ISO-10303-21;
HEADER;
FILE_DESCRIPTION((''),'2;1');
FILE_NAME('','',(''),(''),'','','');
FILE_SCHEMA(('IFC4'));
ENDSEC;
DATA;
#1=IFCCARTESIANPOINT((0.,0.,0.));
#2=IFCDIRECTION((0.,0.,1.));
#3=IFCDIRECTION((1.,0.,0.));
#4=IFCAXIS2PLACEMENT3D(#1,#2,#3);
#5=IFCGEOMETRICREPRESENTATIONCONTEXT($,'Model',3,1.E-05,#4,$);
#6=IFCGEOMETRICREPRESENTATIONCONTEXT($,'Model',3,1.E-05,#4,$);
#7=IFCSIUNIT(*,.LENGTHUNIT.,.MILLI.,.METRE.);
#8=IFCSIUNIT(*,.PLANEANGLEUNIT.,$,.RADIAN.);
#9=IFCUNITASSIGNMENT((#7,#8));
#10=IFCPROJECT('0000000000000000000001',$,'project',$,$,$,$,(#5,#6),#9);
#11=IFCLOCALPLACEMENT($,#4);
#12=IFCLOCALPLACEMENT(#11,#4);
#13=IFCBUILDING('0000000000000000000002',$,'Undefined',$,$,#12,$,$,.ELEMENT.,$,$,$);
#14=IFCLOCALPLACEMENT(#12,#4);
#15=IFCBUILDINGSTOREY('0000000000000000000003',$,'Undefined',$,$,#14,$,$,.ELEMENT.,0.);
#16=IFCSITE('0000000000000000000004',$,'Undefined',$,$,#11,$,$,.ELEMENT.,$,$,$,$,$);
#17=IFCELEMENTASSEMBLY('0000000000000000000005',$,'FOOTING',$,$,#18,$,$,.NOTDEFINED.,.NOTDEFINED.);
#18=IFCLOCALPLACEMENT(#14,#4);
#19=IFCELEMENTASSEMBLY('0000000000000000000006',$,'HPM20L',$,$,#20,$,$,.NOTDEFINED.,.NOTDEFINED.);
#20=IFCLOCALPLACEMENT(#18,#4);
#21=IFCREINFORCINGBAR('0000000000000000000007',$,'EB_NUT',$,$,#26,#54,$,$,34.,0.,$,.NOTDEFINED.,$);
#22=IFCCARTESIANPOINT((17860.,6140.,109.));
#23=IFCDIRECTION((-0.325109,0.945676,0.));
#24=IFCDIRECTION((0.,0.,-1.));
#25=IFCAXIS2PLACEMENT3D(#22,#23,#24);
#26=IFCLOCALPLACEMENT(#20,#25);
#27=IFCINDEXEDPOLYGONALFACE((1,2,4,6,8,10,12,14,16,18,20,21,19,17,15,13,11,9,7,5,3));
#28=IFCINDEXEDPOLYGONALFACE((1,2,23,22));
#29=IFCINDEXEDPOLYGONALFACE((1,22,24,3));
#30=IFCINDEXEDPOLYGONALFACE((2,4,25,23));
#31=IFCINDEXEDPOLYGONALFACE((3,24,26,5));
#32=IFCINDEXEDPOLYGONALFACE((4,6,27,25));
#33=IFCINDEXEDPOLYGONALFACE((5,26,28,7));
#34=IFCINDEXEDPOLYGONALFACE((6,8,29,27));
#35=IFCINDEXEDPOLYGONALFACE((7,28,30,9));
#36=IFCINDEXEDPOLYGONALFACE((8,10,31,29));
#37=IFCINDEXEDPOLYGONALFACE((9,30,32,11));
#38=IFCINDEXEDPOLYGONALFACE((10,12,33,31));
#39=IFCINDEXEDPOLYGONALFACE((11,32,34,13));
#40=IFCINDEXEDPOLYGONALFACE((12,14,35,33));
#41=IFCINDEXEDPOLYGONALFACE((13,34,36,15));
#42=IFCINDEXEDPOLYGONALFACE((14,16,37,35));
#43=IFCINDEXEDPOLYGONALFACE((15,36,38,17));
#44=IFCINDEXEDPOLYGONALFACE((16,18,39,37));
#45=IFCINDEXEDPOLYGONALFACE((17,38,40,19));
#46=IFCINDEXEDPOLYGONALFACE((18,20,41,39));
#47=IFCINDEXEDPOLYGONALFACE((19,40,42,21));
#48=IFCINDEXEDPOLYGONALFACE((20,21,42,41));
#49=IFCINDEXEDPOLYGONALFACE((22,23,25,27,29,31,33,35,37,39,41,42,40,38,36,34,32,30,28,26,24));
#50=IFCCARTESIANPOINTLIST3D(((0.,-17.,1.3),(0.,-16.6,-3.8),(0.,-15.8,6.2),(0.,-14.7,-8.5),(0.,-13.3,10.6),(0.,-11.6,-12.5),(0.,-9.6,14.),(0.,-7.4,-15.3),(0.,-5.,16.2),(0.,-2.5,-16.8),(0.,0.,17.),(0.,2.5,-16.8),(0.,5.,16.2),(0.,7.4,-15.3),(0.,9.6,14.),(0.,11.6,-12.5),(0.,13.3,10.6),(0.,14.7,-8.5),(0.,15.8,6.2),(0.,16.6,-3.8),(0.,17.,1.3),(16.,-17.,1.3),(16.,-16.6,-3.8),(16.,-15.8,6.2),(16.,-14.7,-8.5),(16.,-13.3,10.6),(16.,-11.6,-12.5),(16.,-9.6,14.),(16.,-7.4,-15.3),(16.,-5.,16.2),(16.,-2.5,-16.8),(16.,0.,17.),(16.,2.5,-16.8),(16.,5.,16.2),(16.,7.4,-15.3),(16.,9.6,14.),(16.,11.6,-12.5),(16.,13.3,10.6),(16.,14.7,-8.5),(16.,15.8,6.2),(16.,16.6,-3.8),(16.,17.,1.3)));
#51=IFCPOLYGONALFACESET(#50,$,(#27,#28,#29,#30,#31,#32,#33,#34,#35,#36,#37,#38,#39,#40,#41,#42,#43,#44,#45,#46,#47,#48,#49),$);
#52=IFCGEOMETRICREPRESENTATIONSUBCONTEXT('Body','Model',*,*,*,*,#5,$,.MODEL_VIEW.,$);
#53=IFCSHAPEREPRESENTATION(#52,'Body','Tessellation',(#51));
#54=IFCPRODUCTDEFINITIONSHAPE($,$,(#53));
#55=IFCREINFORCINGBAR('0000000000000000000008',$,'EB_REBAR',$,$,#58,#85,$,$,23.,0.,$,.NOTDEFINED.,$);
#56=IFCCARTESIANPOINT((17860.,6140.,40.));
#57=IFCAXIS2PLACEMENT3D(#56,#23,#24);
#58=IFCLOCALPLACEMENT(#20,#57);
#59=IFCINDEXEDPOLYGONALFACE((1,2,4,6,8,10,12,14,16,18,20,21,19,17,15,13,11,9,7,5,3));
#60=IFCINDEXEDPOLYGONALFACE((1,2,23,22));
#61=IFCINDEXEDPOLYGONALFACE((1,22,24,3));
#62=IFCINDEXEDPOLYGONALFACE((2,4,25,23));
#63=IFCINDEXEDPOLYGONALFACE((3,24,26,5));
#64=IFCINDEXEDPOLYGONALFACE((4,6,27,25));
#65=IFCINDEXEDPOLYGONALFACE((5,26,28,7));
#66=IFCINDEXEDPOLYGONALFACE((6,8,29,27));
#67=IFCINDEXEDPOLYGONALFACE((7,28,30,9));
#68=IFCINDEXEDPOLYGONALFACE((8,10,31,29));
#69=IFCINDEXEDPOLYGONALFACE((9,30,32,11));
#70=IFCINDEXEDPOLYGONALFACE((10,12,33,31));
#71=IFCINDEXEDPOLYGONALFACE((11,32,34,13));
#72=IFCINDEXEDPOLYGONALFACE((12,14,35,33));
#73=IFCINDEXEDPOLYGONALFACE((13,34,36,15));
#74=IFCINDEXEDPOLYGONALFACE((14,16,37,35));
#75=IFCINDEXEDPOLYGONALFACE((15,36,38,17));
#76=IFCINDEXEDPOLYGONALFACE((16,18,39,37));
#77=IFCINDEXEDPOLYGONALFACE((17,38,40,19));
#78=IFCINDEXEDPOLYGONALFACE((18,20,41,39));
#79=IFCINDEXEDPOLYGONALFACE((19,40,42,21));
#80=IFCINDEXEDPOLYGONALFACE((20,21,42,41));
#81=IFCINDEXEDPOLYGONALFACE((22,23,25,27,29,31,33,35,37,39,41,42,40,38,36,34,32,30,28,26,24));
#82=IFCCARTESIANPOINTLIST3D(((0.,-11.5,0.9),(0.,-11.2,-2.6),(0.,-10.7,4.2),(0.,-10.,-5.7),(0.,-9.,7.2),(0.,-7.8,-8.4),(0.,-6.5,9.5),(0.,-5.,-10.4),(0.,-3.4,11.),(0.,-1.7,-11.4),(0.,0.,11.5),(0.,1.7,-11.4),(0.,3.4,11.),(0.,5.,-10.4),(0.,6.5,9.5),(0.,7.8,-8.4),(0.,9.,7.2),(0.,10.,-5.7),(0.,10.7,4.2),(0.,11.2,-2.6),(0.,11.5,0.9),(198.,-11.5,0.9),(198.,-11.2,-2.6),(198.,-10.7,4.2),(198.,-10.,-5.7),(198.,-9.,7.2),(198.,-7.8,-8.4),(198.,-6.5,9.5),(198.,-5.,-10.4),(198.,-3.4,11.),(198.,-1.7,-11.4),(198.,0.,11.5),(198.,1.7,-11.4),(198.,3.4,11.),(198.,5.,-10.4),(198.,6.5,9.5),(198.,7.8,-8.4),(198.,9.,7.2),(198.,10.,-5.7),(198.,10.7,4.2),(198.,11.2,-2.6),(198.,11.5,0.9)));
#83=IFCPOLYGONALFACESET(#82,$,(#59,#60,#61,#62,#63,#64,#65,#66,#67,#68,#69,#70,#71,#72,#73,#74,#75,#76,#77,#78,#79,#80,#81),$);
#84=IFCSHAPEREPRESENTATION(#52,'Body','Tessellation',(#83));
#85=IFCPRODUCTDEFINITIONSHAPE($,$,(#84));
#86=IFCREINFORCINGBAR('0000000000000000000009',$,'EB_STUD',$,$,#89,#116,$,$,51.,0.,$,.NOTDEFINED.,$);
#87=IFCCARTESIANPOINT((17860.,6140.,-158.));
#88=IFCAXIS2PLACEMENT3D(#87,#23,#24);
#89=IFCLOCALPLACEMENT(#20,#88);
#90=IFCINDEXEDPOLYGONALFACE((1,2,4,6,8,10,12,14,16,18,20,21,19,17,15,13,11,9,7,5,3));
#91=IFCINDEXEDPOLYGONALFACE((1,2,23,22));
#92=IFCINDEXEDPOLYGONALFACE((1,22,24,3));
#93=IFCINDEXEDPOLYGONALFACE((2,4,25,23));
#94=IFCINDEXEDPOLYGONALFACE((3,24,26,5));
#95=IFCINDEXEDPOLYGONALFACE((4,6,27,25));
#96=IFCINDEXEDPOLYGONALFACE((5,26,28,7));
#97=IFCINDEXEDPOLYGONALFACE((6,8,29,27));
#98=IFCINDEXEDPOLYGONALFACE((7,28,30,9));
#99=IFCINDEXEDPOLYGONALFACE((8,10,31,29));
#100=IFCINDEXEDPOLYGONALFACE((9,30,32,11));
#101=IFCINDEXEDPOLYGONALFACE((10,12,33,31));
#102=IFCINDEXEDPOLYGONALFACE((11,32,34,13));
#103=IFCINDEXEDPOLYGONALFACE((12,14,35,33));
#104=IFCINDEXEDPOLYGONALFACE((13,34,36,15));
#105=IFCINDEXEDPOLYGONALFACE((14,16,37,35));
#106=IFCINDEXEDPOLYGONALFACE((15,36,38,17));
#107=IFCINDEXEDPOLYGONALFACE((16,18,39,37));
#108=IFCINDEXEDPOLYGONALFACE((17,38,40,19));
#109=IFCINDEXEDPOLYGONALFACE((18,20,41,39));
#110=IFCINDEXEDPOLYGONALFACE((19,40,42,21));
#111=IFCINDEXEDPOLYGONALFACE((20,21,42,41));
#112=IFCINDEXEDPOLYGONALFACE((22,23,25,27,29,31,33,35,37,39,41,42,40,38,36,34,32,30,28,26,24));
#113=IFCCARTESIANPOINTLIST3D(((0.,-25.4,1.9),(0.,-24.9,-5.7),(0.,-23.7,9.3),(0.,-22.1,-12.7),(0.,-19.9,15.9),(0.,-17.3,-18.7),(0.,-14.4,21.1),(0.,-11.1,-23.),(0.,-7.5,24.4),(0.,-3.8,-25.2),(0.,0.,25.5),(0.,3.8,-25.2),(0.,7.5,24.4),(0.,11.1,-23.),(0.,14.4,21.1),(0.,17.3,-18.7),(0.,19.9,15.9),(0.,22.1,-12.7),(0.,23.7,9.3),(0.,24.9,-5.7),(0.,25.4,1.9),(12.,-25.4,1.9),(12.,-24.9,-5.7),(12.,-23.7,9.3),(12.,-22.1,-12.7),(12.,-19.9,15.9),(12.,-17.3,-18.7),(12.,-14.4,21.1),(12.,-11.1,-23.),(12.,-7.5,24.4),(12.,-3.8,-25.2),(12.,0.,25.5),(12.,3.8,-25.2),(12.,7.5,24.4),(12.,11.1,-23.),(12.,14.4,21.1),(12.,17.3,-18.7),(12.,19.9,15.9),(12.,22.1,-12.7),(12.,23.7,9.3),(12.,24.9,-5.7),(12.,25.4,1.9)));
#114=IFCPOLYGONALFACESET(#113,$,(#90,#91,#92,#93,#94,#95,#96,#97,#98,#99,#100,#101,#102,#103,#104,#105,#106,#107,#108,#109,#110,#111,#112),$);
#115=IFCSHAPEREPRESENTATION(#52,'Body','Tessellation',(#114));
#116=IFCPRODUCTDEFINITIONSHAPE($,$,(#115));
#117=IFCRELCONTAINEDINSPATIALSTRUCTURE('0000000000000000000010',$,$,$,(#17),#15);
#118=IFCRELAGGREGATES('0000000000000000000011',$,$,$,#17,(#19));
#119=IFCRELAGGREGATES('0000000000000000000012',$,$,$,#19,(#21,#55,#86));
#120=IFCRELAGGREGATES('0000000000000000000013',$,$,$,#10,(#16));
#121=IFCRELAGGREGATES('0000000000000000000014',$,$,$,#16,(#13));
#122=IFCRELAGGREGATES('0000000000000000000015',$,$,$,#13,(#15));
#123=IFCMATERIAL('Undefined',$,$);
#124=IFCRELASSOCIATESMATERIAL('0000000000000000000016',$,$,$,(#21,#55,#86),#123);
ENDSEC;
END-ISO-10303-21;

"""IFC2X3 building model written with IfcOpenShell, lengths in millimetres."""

from ifc_helpers import new_model, entity, si_unit, frame, origin_with_axes, place, context, subcontext, project, spatial, source, transform, mapped, material, element, aggregate, save


model = new_model("IFC2X3")

# Units and contexts
model_context_1 = context("Model", 3, precision=1e-05, world=origin_with_axes())
model_context_2 = context("Model", 3, precision=1e-05, world=origin_with_axes())
body_context = subcontext(model_context_1, "Body", "Model", "MODEL_VIEW")
ifc_project = project(units=[si_unit("LENGTHUNIT", "METRE", prefix="MILLI"), si_unit("PLANEANGLEUNIT", "RADIAN")], contexts=[model_context_1, model_context_2])

# Site, building, storey
site_placement = place(None, origin_with_axes())
site = spatial("IfcSite", under=ifc_project, at=site_placement, Name="Undefined", CompositionType="ELEMENT")
building_placement = place(site_placement, origin_with_axes())
building = spatial("IfcBuilding", under=site, at=building_placement, Name="Undefined", CompositionType="ELEMENT")
storey_placement = place(building_placement, origin_with_axes())
storey = spatial("IfcBuildingStorey", under=building, at=storey_placement, Name="Undefined", CompositionType="ELEMENT", Elevation=0.0)

# Shared definitions
ifc_material_1 = material(Name="Undefined")

# Element assemblies, reinforcing bars
assembly_1_placement = place(storey_placement, origin_with_axes())
assembly_1 = element("IfcElementAssembly", 1, at=assembly_1_placement, inside=storey, Name="FOOTING", AssemblyPlace="NOTDEFINED", PredefinedType="NOTDEFINED")
assembly_2_placement = place(assembly_1_placement, origin_with_axes())
assembly_2 = element("IfcElementAssembly", 2, at=assembly_2_placement, Name="HPM20L", AssemblyPlace="NOTDEFINED", PredefinedType="NOTDEFINED")
aggregate(assembly_1, [assembly_2])
shared_shape_1 = source(origin_with_axes(), body_context, "Body", "AdvancedSweptSolid", [
    entity("IfcSweptDiskSolid", entity("IfcTrimmedCurve", entity("IfcLine", entity("IfcCartesianPoint", [0.0, 0.0, 0.0]), entity("IfcVector", entity("IfcDirection", [1.0, 0.0, 0.0]), 1.0)), [entity("IfcParameterValue", 0.0)], [entity("IfcParameterValue", 16.0)], True, "PARAMETER"), 17.0, None, 0.0, 16.0),
])
reinforcing_bar_1_placement = place(assembly_2_placement, frame((17860.0, 6140.0, 109.0), z_axis=(-0.325109, 0.945676, 0.0), x_axis=(0.0, 0.0, -1.0)))
reinforcing_bar_1 = element("IfcReinforcingBar", 3, at=reinforcing_bar_1_placement, material=ifc_material_1, Name="EB_NUT", BarRole="NOTDEFINED", CrossSectionArea=0.0, NominalDiameter=34.0, context=body_context, shape_type="MappedRepresentation", body=[
    mapped(shared_shape_1, transform((0.0, 0.0, 0.0))),
])
shared_shape_2 = source(origin_with_axes(), body_context, "Body", "AdvancedSweptSolid", [
    entity("IfcSweptDiskSolid", entity("IfcTrimmedCurve", entity("IfcLine", entity("IfcCartesianPoint", [0.0, 0.0, 0.0]), entity("IfcVector", entity("IfcDirection", [1.0, 0.0, 0.0]), 1.0)), [entity("IfcParameterValue", 0.0)], [entity("IfcParameterValue", 198.0)], True, "PARAMETER"), 11.5, None, 0.0, 198.0),
])
reinforcing_bar_2_placement = place(assembly_2_placement, frame((17860.0, 6140.0, 40.0), z_axis=(-0.325109, 0.945676, 0.0), x_axis=(0.0, 0.0, -1.0)))
reinforcing_bar_2 = element("IfcReinforcingBar", 4, at=reinforcing_bar_2_placement, material=ifc_material_1, Name="EB_REBAR", BarRole="NOTDEFINED", CrossSectionArea=0.0, NominalDiameter=23.0, context=body_context, shape_type="MappedRepresentation", body=[
    mapped(shared_shape_2, transform((0.0, 0.0, 0.0))),
])
shared_shape_3 = source(origin_with_axes(), body_context, "Body", "AdvancedSweptSolid", [
    entity("IfcSweptDiskSolid", entity("IfcTrimmedCurve", entity("IfcLine", entity("IfcCartesianPoint", [0.0, 0.0, 0.0]), entity("IfcVector", entity("IfcDirection", [1.0, 0.0, 0.0]), 1.0)), [entity("IfcParameterValue", 0.0)], [entity("IfcParameterValue", 12.0)], True, "PARAMETER"), 25.5, None, 0.0, 12.0),
])
reinforcing_bar_3_placement = place(assembly_2_placement, frame((17860.0, 6140.0, -158.0), z_axis=(-0.325109, 0.945676, 0.0), x_axis=(0.0, 0.0, -1.0)))
reinforcing_bar_3 = element("IfcReinforcingBar", 5, at=reinforcing_bar_3_placement, material=ifc_material_1, Name="EB_STUD", BarRole="NOTDEFINED", CrossSectionArea=0.0, NominalDiameter=51.0, context=body_context, shape_type="MappedRepresentation", body=[
    mapped(shared_shape_3, transform((0.0, 0.0, 0.0))),
])
aggregate(assembly_2, [reinforcing_bar_1, reinforcing_bar_2, reinforcing_bar_3])

save(model, "model.ifc")
